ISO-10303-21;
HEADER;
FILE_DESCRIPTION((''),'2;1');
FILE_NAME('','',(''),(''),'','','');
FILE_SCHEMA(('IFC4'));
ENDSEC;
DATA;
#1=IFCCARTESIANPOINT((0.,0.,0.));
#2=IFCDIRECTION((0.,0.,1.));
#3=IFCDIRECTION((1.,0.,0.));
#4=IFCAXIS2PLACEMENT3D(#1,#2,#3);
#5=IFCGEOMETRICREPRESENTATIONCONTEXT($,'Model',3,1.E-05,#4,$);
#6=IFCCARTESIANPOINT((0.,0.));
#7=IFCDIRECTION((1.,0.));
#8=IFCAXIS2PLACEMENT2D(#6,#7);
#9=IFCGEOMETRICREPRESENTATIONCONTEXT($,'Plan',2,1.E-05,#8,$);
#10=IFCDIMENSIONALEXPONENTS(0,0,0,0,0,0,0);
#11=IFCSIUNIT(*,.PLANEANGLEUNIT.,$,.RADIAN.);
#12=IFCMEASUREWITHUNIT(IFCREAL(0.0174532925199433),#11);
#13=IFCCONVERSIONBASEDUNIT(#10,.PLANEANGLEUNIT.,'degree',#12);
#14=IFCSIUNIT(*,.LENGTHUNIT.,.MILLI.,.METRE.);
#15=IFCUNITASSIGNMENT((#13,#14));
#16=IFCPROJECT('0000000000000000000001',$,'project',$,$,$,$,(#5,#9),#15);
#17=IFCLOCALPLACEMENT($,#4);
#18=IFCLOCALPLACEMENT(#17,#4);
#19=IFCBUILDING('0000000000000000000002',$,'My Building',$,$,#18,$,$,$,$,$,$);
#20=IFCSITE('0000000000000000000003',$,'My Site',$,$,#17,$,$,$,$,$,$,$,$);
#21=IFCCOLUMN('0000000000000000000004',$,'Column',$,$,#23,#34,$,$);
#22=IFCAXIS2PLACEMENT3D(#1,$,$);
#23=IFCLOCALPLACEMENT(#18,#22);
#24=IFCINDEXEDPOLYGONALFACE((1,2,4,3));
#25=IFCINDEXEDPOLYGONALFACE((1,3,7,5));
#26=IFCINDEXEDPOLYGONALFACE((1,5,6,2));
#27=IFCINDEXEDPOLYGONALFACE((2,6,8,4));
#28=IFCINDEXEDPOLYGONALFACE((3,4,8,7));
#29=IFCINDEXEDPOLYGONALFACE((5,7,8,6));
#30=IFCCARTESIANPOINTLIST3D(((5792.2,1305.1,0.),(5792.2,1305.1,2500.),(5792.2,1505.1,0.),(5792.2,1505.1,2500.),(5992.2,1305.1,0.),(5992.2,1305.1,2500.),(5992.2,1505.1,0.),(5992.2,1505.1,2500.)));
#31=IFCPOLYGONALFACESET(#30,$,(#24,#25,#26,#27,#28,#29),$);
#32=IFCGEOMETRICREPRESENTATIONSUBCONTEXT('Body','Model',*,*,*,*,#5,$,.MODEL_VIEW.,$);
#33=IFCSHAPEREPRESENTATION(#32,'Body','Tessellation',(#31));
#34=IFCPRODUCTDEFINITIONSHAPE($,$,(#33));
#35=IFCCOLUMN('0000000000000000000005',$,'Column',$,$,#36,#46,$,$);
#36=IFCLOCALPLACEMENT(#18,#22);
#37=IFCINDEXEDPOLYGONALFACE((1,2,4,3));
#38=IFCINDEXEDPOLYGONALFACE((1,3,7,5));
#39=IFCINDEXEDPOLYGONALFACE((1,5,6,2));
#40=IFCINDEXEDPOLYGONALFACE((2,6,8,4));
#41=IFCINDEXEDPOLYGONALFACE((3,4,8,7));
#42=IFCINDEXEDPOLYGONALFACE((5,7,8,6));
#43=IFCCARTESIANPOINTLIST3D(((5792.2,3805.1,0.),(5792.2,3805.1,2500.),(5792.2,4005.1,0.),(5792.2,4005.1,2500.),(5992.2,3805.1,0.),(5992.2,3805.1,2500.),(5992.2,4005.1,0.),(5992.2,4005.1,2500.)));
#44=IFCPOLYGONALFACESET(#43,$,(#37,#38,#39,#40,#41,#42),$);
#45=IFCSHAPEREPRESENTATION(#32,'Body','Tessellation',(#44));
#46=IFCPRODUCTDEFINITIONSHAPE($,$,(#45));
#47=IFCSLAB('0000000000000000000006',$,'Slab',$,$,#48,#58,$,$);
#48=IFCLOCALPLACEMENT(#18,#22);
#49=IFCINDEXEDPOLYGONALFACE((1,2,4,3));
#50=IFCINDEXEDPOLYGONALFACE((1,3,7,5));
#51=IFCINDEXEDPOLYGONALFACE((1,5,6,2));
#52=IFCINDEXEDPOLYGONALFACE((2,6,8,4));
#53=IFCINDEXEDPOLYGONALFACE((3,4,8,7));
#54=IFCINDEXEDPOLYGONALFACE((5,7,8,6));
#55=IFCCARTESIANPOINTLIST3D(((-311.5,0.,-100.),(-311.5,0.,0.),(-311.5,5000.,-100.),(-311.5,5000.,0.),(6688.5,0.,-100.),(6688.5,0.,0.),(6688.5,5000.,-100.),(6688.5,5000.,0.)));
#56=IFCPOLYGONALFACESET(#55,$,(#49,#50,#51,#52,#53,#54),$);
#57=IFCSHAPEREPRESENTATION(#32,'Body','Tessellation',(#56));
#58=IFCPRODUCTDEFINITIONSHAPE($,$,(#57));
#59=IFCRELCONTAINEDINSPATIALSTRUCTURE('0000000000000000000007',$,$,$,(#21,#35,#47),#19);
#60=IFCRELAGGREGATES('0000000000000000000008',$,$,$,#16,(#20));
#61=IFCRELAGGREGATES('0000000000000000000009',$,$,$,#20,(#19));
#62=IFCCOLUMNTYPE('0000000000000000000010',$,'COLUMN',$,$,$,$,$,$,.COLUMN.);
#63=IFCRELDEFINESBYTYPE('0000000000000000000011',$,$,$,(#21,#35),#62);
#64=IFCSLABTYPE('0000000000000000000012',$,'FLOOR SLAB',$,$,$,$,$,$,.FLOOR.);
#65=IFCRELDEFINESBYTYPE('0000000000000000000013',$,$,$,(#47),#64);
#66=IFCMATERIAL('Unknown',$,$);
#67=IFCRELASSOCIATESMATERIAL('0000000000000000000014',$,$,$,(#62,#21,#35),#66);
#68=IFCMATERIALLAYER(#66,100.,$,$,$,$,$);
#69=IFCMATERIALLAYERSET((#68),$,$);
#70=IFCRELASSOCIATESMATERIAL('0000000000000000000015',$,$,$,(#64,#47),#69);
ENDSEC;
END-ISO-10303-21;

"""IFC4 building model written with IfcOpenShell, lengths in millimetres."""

from ifc_helpers import new_model, entity, si_unit, converted_unit, frame, origin_with_axes, origin_2d_with_axis, place, context, subcontext, project, spatial, indexed_curve, rectangle, outline, extrude, material, layer, layer_set, layer_usage, material_profile, profile_set, profile_usage, type_object, element, save


model = new_model("IFC4")

# Units and contexts
model_context = context("Model", 3, precision=1e-05, world=origin_with_axes())
plan_context = context("Plan", 2, precision=1e-05, world=origin_2d_with_axis())
body_context = subcontext(model_context, "Body", "Model", "MODEL_VIEW")
ifc_project = project(units=[converted_unit("PLANEANGLEUNIT", "degree", entity("IfcReal", 0.0174532925199433), si_unit("PLANEANGLEUNIT", "RADIAN"), dimensions=[0, 0, 0, 0, 0, 0, 0]), si_unit("LENGTHUNIT", "METRE", prefix="MILLI")], contexts=[model_context, plan_context])

# Site, building
site_placement = place(None, origin_with_axes())
site = spatial("IfcSite", under=ifc_project, at=site_placement, Name="My Site")
building_placement = place(site_placement, origin_with_axes())
building = spatial("IfcBuilding", under=site, at=building_placement, Name="My Building")

# Columns
ifc_material = material(Name="Unknown")
ifc_material_profile = material_profile(ifc_material, rectangle(XDim=200.0, YDim=200.0))
ifc_profile_set = profile_set([ifc_material_profile])
ifc_profile_usage_1 = profile_usage(ifc_profile_set, cardinal=5)
column_type = type_object("IfcColumnType", Name="COLUMN", PredefinedType="COLUMN", material=ifc_profile_set)
column_1_placement = place(building_placement, frame((5892.2, 1405.1, 0.0), z_axis=(0.0, 0.0, 1.0), x_axis=(1.0, 0.0, 0.0)))
element("IfcColumn", 1, at=column_1_placement, inside=building, type_object=column_type, material=ifc_profile_usage_1, Name="Column", context=body_context, shape_type="SweptSolid", body=[
    extrude(rectangle(XDim=200.0, YDim=200.0), origin_with_axes(), (0.0, 0.0, 1.0), 2500.0),
])
ifc_profile_usage_2 = profile_usage(ifc_profile_set, cardinal=5)
column_2_placement = place(building_placement, frame((5892.2, 3905.1, 0.0), z_axis=(0.0, 0.0, 1.0), x_axis=(1.0, 0.0, 0.0)))
element("IfcColumn", 2, at=column_2_placement, inside=building, type_object=column_type, material=ifc_profile_usage_2, Name="Column", context=body_context, shape_type="SweptSolid", body=[
    extrude(rectangle(XDim=200.0, YDim=200.0), origin_with_axes(), (0.0, 0.0, 1.0), 2500.0),
])

# Slab
ifc_layer = layer(ifc_material, 100.0)
ifc_layer_set = layer_set([ifc_layer])
ifc_layer_usage = layer_usage(ifc_layer_set, "AXIS3", "POSITIVE", -100.0)
slab_type = type_object("IfcSlabType", Name="FLOOR SLAB", PredefinedType="FLOOR", material=ifc_layer_set)
slab_placement = place(building_placement, frame((-311.5, 0.0, 0.0), z_axis=(0.0, 0.0, 1.0), x_axis=(1.0, 0.0, 0.0)))
element("IfcSlab", 3, at=slab_placement, inside=building, type_object=slab_type, material=ifc_layer_usage, Name="Slab", context=body_context, shape_type="SweptSolid", body=[
    extrude(outline(indexed_curve([(0.0, 0.0), (7000.0, 0.0), (7000.0, 5000.0), (0.0, 5000.0), (0.0, 0.0)])), frame((0.0, 0.0, -100.0), z_axis=(0.0, 0.0, 1.0), x_axis=(1.0, 0.0, 0.0)), (0.0, 0.0, 1.0), 100.0),
])

save(model, "model.ifc")
